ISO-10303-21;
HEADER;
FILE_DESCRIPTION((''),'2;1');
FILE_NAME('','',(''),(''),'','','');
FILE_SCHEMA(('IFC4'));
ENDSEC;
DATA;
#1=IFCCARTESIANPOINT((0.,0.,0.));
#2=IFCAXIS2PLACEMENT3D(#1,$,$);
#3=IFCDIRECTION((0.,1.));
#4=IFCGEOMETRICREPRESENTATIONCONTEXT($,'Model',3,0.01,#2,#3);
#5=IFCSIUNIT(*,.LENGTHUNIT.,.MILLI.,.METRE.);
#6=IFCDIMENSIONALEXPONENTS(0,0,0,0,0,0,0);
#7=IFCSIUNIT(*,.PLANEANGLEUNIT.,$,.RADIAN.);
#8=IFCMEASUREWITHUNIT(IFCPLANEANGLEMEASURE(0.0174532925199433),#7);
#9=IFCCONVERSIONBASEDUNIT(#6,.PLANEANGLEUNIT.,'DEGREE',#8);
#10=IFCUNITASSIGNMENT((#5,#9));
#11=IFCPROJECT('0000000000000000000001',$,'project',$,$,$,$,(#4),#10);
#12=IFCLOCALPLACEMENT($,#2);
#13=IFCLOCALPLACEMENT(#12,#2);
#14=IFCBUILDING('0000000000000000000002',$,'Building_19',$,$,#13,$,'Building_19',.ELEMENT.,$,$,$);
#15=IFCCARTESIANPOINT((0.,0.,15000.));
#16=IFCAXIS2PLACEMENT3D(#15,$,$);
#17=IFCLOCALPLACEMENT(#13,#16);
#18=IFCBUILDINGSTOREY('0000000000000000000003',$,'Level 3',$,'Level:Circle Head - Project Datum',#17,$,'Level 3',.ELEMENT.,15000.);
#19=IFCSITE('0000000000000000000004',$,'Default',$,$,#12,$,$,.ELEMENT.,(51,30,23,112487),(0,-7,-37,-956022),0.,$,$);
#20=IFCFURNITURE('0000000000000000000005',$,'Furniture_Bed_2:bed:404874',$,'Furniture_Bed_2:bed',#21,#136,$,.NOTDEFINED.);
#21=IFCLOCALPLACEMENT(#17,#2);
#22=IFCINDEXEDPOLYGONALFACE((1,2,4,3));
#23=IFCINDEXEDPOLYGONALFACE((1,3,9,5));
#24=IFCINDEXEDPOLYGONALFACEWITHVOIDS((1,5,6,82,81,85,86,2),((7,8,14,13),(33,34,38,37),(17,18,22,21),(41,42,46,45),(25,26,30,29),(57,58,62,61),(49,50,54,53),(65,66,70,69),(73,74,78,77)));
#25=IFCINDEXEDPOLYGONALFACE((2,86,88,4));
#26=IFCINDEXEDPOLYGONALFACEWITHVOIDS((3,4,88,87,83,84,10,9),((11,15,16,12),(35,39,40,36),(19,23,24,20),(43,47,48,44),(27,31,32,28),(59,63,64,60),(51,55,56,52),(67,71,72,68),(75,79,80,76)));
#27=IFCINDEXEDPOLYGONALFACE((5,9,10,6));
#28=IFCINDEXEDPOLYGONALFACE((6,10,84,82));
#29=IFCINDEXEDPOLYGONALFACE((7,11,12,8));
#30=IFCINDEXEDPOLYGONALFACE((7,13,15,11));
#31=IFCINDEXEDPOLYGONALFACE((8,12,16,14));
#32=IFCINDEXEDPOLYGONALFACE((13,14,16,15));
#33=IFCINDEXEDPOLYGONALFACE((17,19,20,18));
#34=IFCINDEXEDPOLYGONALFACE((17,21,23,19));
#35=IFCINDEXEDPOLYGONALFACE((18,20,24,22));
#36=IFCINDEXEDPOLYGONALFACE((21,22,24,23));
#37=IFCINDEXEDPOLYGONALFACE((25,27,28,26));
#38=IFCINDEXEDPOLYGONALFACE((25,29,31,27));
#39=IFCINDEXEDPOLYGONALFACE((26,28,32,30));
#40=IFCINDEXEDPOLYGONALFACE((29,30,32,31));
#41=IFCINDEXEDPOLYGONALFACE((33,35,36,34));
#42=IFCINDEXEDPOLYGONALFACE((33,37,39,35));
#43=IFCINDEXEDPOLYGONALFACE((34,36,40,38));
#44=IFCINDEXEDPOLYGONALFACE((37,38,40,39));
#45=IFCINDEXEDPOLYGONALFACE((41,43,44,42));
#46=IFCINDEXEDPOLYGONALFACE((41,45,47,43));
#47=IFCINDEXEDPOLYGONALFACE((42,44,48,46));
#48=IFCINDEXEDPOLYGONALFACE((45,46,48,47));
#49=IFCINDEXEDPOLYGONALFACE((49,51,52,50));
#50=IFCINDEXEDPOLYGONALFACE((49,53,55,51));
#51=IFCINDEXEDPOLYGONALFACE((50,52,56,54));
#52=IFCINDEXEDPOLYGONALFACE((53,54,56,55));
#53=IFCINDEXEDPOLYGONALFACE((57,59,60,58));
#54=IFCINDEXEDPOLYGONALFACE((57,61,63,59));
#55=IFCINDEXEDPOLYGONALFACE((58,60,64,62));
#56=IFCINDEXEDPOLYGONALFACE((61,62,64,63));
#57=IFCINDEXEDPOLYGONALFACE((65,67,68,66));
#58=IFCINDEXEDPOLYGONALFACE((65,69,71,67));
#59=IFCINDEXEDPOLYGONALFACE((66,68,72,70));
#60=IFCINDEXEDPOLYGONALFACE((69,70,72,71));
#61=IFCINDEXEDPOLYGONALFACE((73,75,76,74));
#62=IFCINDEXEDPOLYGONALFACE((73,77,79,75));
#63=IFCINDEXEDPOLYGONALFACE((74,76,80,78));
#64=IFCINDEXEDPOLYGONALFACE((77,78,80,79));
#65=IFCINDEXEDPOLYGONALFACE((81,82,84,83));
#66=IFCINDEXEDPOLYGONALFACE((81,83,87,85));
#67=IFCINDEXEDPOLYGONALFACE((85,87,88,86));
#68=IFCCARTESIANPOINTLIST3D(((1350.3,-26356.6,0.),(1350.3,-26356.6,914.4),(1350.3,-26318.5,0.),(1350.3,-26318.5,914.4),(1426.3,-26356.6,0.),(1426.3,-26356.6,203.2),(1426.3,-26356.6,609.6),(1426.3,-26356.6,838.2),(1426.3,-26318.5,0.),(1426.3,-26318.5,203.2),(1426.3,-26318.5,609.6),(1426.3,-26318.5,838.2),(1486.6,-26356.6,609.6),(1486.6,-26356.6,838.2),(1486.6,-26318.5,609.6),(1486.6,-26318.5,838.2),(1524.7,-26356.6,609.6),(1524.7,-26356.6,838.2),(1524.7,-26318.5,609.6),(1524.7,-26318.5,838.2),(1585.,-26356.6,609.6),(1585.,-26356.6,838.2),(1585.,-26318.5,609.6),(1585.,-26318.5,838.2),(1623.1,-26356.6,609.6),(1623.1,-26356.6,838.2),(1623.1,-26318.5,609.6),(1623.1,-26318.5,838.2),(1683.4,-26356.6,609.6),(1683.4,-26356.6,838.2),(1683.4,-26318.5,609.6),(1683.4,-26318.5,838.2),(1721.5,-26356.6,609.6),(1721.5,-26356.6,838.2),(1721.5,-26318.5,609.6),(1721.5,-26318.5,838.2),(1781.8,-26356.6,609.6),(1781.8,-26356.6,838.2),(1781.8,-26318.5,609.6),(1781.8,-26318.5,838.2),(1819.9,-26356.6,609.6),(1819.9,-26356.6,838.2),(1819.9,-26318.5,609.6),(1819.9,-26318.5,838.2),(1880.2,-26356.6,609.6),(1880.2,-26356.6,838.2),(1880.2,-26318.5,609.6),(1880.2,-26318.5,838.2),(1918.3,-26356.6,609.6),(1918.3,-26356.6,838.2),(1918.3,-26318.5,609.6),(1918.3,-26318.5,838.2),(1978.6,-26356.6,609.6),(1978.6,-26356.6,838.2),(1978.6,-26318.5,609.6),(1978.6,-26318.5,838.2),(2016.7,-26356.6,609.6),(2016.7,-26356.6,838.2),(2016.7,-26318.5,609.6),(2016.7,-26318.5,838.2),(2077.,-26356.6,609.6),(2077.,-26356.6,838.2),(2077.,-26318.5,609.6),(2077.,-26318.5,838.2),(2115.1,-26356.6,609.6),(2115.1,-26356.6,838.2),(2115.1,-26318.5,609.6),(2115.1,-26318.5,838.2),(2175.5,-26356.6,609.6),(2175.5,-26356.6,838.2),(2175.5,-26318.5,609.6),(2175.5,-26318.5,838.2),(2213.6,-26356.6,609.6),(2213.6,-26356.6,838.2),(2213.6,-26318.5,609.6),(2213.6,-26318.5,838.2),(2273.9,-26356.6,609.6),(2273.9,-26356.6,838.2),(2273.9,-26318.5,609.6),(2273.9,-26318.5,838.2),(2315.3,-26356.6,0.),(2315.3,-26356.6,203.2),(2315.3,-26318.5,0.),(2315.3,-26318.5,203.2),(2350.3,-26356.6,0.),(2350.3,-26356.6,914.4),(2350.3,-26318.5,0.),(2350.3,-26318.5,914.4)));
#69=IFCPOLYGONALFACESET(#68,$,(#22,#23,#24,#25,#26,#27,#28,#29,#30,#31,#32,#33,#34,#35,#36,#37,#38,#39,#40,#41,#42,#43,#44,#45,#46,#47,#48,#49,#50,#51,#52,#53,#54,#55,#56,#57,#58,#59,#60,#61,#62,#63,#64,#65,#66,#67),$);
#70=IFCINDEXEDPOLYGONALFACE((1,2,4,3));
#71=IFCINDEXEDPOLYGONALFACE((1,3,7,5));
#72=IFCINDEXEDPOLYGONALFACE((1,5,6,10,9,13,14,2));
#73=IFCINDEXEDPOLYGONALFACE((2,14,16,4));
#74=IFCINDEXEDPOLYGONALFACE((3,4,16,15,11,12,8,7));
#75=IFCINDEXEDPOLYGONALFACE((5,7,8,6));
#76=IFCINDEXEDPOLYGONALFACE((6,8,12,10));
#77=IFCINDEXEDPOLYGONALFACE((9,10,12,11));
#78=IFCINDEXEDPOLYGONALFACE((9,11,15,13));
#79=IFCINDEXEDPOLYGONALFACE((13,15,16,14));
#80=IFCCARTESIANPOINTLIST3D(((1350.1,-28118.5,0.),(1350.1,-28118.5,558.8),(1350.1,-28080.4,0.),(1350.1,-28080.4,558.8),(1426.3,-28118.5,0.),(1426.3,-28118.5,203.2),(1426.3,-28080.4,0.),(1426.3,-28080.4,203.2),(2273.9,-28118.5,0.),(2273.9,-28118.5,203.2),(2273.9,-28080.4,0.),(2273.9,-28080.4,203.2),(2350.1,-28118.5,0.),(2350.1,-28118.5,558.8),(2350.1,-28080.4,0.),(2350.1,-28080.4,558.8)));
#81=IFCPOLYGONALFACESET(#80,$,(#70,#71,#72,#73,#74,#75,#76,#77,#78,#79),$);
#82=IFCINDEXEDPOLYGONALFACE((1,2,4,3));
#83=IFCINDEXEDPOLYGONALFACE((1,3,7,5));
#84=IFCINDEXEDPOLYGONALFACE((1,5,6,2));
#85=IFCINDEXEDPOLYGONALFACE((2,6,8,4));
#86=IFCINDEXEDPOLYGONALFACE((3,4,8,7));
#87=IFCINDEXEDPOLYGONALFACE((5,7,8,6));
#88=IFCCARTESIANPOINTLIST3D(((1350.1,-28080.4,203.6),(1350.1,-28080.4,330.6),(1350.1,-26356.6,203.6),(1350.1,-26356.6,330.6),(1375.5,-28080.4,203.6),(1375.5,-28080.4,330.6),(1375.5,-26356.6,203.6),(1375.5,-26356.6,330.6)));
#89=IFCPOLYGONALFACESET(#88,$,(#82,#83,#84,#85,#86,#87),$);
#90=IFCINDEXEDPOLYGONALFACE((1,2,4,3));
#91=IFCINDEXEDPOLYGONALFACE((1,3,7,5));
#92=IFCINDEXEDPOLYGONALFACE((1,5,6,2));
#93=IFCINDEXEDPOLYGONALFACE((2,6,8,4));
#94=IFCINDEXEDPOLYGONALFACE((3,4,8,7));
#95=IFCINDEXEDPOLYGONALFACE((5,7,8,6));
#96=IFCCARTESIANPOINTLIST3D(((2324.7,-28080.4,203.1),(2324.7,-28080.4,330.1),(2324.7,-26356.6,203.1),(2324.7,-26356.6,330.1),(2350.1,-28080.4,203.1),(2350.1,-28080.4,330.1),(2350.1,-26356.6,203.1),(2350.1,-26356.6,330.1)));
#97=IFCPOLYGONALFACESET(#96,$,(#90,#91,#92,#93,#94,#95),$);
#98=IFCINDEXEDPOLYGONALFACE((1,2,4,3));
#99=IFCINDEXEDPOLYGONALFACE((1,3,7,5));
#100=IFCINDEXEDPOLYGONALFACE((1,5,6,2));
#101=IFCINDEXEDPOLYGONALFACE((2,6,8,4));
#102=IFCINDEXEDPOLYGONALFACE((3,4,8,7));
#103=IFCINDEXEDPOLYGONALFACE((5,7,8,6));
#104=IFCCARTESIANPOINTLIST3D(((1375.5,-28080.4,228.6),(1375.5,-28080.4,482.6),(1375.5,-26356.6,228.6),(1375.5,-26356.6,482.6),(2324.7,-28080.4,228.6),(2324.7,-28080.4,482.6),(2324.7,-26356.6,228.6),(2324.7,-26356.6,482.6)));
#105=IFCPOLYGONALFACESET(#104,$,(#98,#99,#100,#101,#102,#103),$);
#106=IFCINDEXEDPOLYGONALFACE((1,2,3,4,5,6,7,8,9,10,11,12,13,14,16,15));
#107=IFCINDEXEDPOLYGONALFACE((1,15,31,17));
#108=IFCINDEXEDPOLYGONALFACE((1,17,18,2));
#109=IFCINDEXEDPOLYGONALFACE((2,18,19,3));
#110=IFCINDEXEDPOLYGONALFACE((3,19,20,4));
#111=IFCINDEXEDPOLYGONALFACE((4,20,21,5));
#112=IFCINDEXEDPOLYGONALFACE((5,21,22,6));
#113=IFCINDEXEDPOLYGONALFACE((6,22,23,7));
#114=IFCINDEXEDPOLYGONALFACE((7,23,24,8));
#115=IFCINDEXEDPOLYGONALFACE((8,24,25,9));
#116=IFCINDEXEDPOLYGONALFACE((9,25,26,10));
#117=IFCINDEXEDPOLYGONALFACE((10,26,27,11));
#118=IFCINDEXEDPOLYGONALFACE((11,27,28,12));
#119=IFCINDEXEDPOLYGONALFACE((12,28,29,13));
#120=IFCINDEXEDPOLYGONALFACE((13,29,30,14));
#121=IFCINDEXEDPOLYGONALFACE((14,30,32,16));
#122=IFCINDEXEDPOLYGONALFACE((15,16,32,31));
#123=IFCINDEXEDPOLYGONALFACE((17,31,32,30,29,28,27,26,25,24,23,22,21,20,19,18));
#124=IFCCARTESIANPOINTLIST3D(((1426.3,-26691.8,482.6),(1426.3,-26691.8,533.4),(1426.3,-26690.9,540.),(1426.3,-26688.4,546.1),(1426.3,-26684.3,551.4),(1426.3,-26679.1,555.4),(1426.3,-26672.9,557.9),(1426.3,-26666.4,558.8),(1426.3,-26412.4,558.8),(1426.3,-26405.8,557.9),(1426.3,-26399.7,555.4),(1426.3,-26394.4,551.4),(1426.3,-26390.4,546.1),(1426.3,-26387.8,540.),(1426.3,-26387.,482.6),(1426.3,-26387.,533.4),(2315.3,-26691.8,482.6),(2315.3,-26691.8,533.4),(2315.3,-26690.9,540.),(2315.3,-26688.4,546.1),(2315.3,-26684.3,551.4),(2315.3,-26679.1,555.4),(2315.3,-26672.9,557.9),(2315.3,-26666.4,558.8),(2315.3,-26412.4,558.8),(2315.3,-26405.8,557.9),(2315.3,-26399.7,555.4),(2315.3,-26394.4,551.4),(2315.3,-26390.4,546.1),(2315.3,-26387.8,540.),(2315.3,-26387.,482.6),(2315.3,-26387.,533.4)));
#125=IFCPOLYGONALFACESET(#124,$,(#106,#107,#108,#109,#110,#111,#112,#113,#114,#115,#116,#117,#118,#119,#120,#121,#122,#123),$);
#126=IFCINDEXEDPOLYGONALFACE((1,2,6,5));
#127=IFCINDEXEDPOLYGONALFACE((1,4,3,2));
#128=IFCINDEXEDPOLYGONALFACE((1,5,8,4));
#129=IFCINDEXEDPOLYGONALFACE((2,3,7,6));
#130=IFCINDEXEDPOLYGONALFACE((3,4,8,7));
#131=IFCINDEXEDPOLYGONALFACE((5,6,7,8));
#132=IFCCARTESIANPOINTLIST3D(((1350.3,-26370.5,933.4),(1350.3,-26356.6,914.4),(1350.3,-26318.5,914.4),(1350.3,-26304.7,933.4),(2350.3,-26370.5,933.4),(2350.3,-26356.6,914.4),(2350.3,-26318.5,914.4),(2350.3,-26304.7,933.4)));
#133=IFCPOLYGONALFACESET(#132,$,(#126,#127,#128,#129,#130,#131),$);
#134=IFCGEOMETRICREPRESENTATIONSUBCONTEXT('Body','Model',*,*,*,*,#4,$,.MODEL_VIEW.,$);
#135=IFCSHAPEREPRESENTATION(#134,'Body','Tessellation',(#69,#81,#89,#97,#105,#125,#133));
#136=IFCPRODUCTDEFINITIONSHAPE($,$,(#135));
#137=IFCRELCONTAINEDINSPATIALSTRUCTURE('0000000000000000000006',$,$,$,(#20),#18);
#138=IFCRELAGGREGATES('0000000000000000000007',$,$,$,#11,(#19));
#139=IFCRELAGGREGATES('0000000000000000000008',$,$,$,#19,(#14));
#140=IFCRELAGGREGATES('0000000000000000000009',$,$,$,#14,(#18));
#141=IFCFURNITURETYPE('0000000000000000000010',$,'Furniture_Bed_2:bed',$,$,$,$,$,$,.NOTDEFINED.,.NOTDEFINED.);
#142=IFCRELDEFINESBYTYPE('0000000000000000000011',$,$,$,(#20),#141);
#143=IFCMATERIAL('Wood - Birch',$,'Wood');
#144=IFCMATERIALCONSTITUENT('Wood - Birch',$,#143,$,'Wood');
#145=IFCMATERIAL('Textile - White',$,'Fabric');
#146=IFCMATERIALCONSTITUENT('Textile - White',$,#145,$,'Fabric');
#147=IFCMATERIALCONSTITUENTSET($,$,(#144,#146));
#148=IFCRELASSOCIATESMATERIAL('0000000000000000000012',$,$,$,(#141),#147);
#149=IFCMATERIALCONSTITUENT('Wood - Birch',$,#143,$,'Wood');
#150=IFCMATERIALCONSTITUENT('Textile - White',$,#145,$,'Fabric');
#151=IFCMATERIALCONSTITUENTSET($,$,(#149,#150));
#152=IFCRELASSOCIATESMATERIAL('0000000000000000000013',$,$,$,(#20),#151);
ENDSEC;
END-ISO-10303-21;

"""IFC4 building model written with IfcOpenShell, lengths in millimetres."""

from ifc_helpers import new_model, entity, si_unit, converted_unit, direction, frame, origin, place, context, subcontext, project, spatial, line, arc, indexed_curve, outline, extrude, source, transform, mapped, material, constituent, constituent_set, type_object, type_shapes, element, save


model = new_model("IFC4")

# Units and contexts
model_context = context("Model", 3, precision=0.01, world=origin(), true_north=direction((0.0, 1.0)))
body_context = subcontext(model_context, "Body", "Model", "MODEL_VIEW")
ifc_project = project(units=[si_unit("LENGTHUNIT", "METRE", prefix="MILLI"), converted_unit("PLANEANGLEUNIT", "DEGREE", entity("IfcPlaneAngleMeasure", 0.0174532925199433), si_unit("PLANEANGLEUNIT", "RADIAN"), dimensions=[0, 0, 0, 0, 0, 0, 0])], contexts=[model_context])

# Site, building, storey
site_placement = place(None, origin())
site = spatial("IfcSite", under=ifc_project, at=site_placement, Name="Default", CompositionType="ELEMENT", RefLatitude=(51, 30, 23, 112487), RefLongitude=(0, -7, -37, -956022), RefElevation=0.0)
building_placement = place(site_placement, origin())
building = spatial("IfcBuilding", under=site, at=building_placement, Name="Building_19", LongName="Building_19", CompositionType="ELEMENT")
storey_placement = place(building_placement, frame((0.0, 0.0, 15000.0)))
storey = spatial("IfcBuildingStorey", under=building, at=storey_placement, Name="Level 3", ObjectType="Level:Circle Head - Project Datum", LongName="Level 3", CompositionType="ELEMENT", Elevation=15000.0)

# Furniture
ifc_material_1 = material(Name="Wood - Birch", Category="Wood")
ifc_material_2 = material(Name="Textile - White", Category="Fabric")
ifc_constituent_1 = constituent(ifc_material_1, Name="Wood - Birch", Category="Wood")
ifc_constituent_2 = constituent(ifc_material_2, Name="Textile - White", Category="Fabric")
ifc_constituent_set_1 = constituent_set(constituents=[ifc_constituent_1, ifc_constituent_2])
furniture_type_1 = type_object("IfcFurnitureType", Name="Furniture_Bed_2:bed", AssemblyPlace="NOTDEFINED", PredefinedType="NOTDEFINED", material=ifc_constituent_set_1)
shared_shape_1 = source(origin(), body_context, "Body", "SweptSolid", [
    extrude(outline(indexed_curve([(-635.0, -489.8), (279.4, -489.8), (279.4, -454.7), (76.2, -454.7), (76.2, 434.3), (279.4, 434.3), (279.4, 510.3), (-635.0, 510.3), (-635.0, -489.8)], self_intersect=False), holes=[indexed_curve([(-558.8, 374.0), (-558.8, 434.3), (-330.2, 434.3), (-330.2, 374.0), (-558.8, 374.0)], self_intersect=False), indexed_curve([(-558.8, 275.5), (-558.8, 335.9), (-330.2, 335.9), (-330.2, 275.5), (-558.8, 275.5)], self_intersect=False), indexed_curve([(-558.8, 177.1), (-558.8, 237.4), (-330.2, 237.4), (-330.2, 177.1), (-558.8, 177.1)], self_intersect=False), indexed_curve([(-558.8, 78.7), (-558.8, 139.0), (-330.2, 139.0), (-330.2, 78.7), (-558.8, 78.7)], self_intersect=False), indexed_curve([(-558.8, -118.1), (-558.8, -57.8), (-330.2, -57.8), (-330.2, -118.1), (-558.8, -118.1)], self_intersect=False), indexed_curve([(-558.8, -216.5), (-558.8, -156.2), (-330.2, -156.2), (-330.2, -216.5), (-558.8, -216.5)], self_intersect=False), indexed_curve([(-558.8, -314.9), (-558.8, -254.6), (-330.2, -254.6), (-330.2, -314.9), (-558.8, -314.9)], self_intersect=False), indexed_curve([(-558.8, -413.3), (-558.8, -353.0), (-330.2, -353.0), (-330.2, -413.3), (-558.8, -413.3)], self_intersect=False), indexed_curve([(-558.8, -19.7), (-558.8, 40.6), (-330.2, 40.6), (-330.2, -19.7), (-558.8, -19.7)], self_intersect=False)]), frame((-8.6, -38.1, 279.4), z_axis=(0.0, 1.0, 0.0), x_axis=(0.0, 0.0, -1.0)), (0.0, 0.0, 1.0), 38.1),
    extrude(outline(indexed_curve([(423.8, -190.5), (500.0, -190.5), (500.0, 368.3), (-500.0, 368.3), (-500.0, -190.5), (-423.8, -190.5), (-423.8, 12.7), (423.8, 12.7), (423.8, -190.5)], self_intersect=False)), frame((-19.1, -1800.0, 190.5), z_axis=(0.0, 1.0, 0.0), x_axis=(-1.0, 0.0, 0.0)), (0.0, 0.0, 1.0), 38.1),
    extrude(outline(indexed_curve([(-12.7, -861.9), (12.7, -861.9), (12.7, 861.9), (-12.7, 861.9), (-12.7, -861.9)], self_intersect=False)), frame((-506.4, -900.0, 203.6)), (0.0, 0.0, 1.0), 127.0),
    extrude(outline(indexed_curve([(-12.7, -861.9), (12.7, -861.9), (12.7, 861.9), (-12.7, 861.9), (-12.7, -861.9)], self_intersect=False)), frame((468.2, -900.0, 203.1)), (0.0, 0.0, 1.0), 127.0),
    extrude(outline(indexed_curve([(-474.6, -861.9), (474.6, -861.9), (474.6, 861.9), (-474.6, 861.9), (-474.6, -861.9)], self_intersect=False)), frame((-19.0, -900.0, 228.6), z_axis=(0.0, 0.0, 1.0), x_axis=(-1.0, 0.0, 0.0)), (0.0, 0.0, 1.0), 254.0),
    extrude(outline(indexed_curve([(-152.4, -42.3), (152.4, -42.3), (152.4, 8.5), (145.0, 26.4), (127.0, 33.9), (-127.0, 33.9), (-145.0, 26.4), (-152.4, 8.5)], segments=[line(1, 2, 3), arc(3, 4, 5), line(5, 6), arc(6, 7, 8), line(8, 1)], self_intersect=False)), frame((-442.9, -220.8, 524.9), z_axis=(1.0, 0.0, 0.0), x_axis=(0.0, 1.0, 0.0)), (0.0, 0.0, 1.0), 889.0),
    extrude(outline(indexed_curve([(-19.1, -9.5), (19.0, -9.5), (32.9, 9.5), (-32.9, 9.5), (-19.1, -9.5)], self_intersect=False)), frame((-518.8, -19.0, 923.9), z_axis=(1.0, 0.0, 0.0), x_axis=(0.0, 1.0, 0.0)), (0.0, 0.0, 1.0), 1000.1),
])
type_shapes(furniture_type_1, [shared_shape_1])
ifc_constituent_3 = constituent(ifc_material_1, Name="Wood - Birch", Category="Wood")
ifc_constituent_4 = constituent(ifc_material_2, Name="Textile - White", Category="Fabric")
ifc_constituent_set_2 = constituent_set(constituents=[ifc_constituent_3, ifc_constituent_4])
furniture_1_placement = place(storey_placement, frame((1869.1, -26318.5, 0.0)))
element("IfcFurniture", 1, at=furniture_1_placement, inside=storey, type_object=furniture_type_1, material=ifc_constituent_set_2, Name="Furniture_Bed_2:bed:404874", ObjectType="Furniture_Bed_2:bed", PredefinedType="NOTDEFINED", context=body_context, shape_type="MappedRepresentation", body=[
    mapped(shared_shape_1, transform((0.0, 0.0, 0.0), scale=1.0)),
])

save(model, "model.ifc")
